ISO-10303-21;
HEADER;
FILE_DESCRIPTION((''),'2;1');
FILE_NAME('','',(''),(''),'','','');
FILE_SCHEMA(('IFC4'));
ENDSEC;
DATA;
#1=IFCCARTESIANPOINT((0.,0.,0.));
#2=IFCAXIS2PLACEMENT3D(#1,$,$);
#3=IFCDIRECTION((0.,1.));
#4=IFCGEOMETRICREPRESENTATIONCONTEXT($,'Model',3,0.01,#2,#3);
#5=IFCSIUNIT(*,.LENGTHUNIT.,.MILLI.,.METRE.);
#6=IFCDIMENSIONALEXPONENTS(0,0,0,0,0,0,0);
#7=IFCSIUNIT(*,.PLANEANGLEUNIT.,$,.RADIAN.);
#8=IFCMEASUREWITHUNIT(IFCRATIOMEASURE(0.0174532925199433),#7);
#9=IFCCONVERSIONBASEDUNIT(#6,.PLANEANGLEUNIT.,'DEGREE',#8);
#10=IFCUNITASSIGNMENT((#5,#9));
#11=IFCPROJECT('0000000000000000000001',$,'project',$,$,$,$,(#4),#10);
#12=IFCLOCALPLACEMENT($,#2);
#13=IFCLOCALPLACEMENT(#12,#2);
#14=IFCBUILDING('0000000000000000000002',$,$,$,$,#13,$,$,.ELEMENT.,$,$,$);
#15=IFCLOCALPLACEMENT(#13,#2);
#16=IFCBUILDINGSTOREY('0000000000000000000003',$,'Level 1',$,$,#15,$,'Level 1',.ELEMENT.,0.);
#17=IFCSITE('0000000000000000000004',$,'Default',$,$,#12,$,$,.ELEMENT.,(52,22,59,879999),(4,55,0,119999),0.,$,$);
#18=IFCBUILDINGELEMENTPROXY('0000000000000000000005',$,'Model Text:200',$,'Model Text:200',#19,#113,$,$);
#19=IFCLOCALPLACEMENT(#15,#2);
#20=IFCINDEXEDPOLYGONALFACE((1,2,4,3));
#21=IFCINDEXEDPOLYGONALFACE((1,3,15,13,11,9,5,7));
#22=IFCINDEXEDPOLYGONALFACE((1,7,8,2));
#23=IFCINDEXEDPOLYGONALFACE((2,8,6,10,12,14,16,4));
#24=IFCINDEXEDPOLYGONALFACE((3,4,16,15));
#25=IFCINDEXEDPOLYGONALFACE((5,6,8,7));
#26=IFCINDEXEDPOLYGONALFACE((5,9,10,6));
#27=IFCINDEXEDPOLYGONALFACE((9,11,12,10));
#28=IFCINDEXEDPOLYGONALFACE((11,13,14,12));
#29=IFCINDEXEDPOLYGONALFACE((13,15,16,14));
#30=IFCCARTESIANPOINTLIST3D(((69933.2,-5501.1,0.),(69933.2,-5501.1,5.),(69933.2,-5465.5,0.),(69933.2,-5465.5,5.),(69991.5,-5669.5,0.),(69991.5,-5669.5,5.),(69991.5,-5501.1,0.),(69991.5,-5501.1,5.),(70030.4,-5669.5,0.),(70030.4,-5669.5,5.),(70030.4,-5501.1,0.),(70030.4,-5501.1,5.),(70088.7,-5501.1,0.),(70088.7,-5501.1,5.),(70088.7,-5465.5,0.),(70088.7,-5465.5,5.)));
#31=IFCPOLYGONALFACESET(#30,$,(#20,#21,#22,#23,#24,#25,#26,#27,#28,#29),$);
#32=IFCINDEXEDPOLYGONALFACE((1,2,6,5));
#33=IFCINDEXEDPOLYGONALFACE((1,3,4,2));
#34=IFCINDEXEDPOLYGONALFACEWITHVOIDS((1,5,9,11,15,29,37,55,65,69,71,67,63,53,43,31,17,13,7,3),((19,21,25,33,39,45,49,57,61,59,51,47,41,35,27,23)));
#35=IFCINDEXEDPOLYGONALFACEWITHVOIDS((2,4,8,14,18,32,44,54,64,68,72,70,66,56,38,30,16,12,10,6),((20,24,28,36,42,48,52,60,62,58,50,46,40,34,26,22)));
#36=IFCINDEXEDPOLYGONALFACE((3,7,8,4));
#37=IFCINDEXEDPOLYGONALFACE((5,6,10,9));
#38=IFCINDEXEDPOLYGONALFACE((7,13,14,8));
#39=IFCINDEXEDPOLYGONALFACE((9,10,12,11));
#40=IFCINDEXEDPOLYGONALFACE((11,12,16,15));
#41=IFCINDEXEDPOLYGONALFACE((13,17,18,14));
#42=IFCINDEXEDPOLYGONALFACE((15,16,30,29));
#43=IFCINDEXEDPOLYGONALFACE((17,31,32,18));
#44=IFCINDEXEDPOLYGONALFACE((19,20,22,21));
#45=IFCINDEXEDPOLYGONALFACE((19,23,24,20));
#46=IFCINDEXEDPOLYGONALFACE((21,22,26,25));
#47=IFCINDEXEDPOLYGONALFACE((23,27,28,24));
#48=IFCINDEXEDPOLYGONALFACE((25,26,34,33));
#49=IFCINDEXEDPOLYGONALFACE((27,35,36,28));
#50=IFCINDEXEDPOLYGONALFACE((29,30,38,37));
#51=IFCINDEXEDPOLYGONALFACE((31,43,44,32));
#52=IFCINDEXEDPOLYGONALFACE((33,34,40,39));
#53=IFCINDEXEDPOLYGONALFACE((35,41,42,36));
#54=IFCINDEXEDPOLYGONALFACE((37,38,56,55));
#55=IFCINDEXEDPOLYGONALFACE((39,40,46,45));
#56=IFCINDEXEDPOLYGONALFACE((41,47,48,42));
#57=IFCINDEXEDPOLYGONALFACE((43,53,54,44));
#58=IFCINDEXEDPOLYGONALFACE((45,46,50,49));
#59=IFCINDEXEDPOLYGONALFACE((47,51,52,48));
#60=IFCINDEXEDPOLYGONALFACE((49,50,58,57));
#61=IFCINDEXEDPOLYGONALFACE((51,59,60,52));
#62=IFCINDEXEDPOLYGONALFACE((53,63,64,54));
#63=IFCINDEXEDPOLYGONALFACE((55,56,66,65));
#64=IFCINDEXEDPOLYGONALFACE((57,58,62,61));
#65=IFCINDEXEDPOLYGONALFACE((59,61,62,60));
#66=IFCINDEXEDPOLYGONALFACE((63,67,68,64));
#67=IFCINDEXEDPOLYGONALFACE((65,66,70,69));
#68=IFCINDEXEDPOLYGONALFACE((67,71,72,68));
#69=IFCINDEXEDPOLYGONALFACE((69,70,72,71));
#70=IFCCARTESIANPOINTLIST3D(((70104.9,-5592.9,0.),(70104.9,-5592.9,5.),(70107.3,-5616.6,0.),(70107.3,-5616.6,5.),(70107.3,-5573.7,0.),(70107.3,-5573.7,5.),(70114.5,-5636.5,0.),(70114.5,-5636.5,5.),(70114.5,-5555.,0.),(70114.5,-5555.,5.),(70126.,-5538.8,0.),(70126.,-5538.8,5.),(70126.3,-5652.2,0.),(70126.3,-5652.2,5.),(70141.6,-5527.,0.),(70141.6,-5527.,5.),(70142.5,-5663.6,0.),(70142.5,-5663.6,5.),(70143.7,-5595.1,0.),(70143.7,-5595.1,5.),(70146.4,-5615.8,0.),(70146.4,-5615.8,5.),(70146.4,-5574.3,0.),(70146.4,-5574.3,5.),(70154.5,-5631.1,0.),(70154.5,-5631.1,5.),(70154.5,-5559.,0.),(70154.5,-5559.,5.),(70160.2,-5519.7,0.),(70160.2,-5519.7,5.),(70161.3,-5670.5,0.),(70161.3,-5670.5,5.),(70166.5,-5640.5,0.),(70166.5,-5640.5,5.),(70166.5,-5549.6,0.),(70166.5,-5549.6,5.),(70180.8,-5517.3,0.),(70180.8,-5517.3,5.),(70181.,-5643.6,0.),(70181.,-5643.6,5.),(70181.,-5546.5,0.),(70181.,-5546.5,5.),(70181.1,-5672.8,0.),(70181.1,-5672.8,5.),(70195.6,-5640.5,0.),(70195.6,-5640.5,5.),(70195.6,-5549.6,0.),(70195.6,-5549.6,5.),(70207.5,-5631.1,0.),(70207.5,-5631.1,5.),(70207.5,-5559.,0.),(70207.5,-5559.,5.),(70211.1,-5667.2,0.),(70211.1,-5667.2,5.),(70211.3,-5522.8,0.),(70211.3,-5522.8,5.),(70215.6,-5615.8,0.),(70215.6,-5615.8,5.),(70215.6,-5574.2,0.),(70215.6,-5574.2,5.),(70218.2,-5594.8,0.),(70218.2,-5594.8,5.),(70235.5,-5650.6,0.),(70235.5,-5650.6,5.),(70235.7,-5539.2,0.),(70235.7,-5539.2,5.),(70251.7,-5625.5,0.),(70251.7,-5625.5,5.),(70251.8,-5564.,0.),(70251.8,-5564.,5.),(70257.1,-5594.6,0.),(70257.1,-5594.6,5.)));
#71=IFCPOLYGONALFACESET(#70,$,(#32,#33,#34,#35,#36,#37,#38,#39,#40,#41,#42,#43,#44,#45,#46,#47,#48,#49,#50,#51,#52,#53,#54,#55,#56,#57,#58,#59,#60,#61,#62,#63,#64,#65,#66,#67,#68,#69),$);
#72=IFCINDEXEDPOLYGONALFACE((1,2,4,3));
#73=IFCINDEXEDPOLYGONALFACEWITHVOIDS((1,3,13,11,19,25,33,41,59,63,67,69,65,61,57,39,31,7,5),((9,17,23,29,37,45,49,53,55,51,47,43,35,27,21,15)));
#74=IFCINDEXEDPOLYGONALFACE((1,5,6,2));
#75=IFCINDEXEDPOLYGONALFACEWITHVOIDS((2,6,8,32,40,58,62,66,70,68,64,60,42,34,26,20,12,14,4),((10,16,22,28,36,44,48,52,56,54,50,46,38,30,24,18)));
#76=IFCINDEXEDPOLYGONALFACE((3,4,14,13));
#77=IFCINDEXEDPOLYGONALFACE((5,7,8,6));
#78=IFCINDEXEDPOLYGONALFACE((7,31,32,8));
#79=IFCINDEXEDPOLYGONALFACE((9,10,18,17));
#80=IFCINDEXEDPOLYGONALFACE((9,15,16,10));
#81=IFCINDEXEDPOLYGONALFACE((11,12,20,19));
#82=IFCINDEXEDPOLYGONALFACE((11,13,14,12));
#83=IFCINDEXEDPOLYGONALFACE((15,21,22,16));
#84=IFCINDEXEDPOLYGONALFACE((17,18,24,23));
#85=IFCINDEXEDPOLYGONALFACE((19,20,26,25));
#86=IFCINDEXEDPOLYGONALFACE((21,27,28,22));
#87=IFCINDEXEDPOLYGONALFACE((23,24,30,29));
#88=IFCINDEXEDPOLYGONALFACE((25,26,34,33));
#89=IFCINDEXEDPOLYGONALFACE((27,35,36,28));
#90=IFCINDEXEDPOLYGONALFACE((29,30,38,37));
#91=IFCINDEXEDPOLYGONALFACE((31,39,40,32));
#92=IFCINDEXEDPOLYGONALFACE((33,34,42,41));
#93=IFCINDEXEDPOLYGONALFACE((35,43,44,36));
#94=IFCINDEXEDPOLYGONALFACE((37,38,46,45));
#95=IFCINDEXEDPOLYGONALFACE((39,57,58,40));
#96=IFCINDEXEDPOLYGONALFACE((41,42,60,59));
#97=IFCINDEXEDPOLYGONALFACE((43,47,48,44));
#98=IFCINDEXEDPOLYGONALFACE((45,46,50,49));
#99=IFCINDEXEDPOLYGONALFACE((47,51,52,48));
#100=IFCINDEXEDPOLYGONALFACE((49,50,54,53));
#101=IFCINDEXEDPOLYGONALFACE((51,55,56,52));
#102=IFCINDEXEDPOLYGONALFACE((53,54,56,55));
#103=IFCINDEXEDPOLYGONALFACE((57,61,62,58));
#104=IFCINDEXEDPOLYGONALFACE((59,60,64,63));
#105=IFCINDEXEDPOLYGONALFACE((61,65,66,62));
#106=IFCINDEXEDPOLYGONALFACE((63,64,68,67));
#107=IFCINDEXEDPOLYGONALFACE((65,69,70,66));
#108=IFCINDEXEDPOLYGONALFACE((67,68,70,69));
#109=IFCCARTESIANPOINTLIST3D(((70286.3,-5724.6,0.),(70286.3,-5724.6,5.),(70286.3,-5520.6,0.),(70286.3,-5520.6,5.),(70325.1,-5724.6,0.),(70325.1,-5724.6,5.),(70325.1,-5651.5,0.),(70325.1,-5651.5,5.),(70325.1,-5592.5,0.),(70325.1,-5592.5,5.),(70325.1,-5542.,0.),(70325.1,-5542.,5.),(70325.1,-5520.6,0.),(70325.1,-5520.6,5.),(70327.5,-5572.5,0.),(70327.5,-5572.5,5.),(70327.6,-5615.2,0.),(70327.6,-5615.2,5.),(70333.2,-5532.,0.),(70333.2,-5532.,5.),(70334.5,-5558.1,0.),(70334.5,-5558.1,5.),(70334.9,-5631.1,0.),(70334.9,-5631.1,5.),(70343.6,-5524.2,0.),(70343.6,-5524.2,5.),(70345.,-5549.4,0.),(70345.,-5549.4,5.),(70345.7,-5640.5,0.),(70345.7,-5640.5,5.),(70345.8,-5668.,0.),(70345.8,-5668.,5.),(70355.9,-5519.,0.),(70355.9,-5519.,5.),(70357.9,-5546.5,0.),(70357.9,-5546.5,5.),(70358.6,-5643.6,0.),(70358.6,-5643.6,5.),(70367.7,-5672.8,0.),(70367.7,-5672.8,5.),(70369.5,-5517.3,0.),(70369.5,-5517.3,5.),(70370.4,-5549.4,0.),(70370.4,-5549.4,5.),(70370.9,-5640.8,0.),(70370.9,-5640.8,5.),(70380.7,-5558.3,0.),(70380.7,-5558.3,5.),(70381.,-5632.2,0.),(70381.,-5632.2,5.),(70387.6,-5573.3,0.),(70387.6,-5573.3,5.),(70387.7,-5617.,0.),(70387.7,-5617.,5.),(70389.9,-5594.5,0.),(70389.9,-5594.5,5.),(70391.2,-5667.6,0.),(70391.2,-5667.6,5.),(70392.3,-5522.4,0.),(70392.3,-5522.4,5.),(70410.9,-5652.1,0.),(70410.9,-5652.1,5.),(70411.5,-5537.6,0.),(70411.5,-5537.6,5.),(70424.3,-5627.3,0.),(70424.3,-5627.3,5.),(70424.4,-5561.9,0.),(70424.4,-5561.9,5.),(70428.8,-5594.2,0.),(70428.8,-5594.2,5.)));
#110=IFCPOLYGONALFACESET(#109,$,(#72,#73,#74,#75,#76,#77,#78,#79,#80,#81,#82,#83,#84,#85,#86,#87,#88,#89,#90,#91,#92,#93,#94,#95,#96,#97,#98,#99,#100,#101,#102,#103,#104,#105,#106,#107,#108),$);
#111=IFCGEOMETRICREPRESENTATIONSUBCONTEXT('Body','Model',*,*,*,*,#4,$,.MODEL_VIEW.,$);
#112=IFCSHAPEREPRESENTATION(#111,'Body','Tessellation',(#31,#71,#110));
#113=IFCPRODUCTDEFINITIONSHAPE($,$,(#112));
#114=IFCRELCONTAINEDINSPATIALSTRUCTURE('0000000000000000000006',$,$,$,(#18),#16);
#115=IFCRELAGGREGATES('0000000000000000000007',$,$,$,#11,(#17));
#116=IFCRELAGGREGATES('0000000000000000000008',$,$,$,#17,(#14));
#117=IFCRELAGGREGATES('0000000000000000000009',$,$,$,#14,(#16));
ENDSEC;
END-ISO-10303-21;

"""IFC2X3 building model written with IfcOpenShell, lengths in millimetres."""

from ifc_helpers import new_model, entity, si_unit, converted_unit, direction, frame, origin, place, context, subcontext, project, spatial, polyline, outline, extrude, element, save


model = new_model("IFC2X3")

# Units and contexts
model_context = context("Model", 3, precision=0.01, world=origin(), true_north=direction((0.0, 1.0)))
body_context = subcontext(model_context, "Body", "Model", "MODEL_VIEW")
ifc_project = project(units=[si_unit("LENGTHUNIT", "METRE", prefix="MILLI"), converted_unit("PLANEANGLEUNIT", "DEGREE", entity("IfcRatioMeasure", 0.0174532925199433), si_unit("PLANEANGLEUNIT", "RADIAN"), dimensions=[0, 0, 0, 0, 0, 0, 0])], contexts=[model_context])

# Site, building, storey
site_placement = place(None, origin())
site = spatial("IfcSite", under=ifc_project, at=site_placement, Name="Default", CompositionType="ELEMENT", RefLatitude=(52, 22, 59, 879999), RefLongitude=(4, 55, 0, 119999), RefElevation=0.0)
building_placement = place(site_placement, origin())
building = spatial("IfcBuilding", under=site, at=building_placement, CompositionType="ELEMENT")
storey_placement = place(building_placement, origin())
storey = spatial("IfcBuildingStorey", under=building, at=storey_placement, Name="Level 1", LongName="Level 1", CompositionType="ELEMENT", Elevation=0.0)

# Building element proxy
proxy_1_placement = place(building_placement, origin())
element("IfcBuildingElementProxy", 1, at=proxy_1_placement, inside=storey, Name="Model Text:200", ObjectType="Model Text:200", context=body_context, shape_type="SweptSolid", body=[
    extrude(outline(polyline([(-19.4, -135.2), (19.4, -135.2), (19.4, 33.2), (77.7, 33.2), (77.7, 68.8), (-77.7, 68.8), (-77.7, 33.2), (-19.4, 33.2), (-19.4, -135.2)])), frame((70010.9, -5534.3, 0.0)), (0.0, 0.0, 1.0), 5.0),
    extrude(outline(polyline([(-8.8, -65.7), (15.1, -65.7), (35.5, -60.5), (52.3, -50.4), (65.3, -35.4), (74.1, -17.3), (78.4, 2.1), (75.9, 32.5), (61.8, 58.5), (38.4, 77.1), (8.3, 85.6), (-22.7, 83.3), (-49.0, 69.9), (-67.8, 47.3), (-76.3, 17.5), (-76.0, -3.3), (-70.7, -22.5), (-60.5, -39.2), (-45.5, -52.3), (-27.7, -61.4), (-8.8, -65.7)]), holes=[polyline([(-2.7, -27.2), (-23.1, -22.5), (-37.5, -12.9), (-45.7, 0.0), (-47.3, 14.8), (-42.7, 28.9), (-32.2, 39.9), (-16.3, 46.3), (4.5, 46.9), (25.1, 42.1), (39.6, 32.6), (47.7, 19.7), (49.4, 5.0), (44.8, -9.2), (34.2, -20.2), (18.2, -26.7), (-2.7, -27.2)])]), frame((70171.1, -5595.0, 0.0), z_axis=(0.0, 0.0, 1.0), x_axis=(0.100608, -0.994926, 0.0)), (0.0, 0.0, 1.0), 5.0),
    extrude(outline(polyline([(-73.1, -75.4), (130.9, -75.4), (130.9, -36.6), (57.8, -36.6), (74.3, -15.9), (79.1, 6.0), (73.9, 29.5), (58.4, 49.2), (33.6, 62.6), (0.5, 67.1), (-31.8, 62.8), (-56.1, 49.8), (-71.3, 30.7), (-76.4, 7.8), (-74.7, -5.8), (-69.6, -18.1), (-61.7, -28.5), (-51.7, -36.6), (-73.1, -36.6), (-73.1, -75.4)]), holes=[polyline([(-1.2, -36.6), (-21.2, -34.2), (-35.6, -27.2), (-44.3, -16.7), (-47.2, -3.8), (-44.3, 8.7), (-35.4, 19.0), (-20.4, 25.9), (0.8, 28.2), (23.3, 26.0), (38.5, 19.3), (47.1, 9.2), (49.9, -3.1), (46.8, -16.0), (37.4, -26.8), (21.5, -34.1), (-1.2, -36.6)])]), frame((70361.7, -5593.7, 0.0), z_axis=(0.0, 0.0, 1.0), x_axis=(0.0, -1.0, 0.0)), (0.0, 0.0, 1.0), 5.0),
])

save(model, "model.ifc")
